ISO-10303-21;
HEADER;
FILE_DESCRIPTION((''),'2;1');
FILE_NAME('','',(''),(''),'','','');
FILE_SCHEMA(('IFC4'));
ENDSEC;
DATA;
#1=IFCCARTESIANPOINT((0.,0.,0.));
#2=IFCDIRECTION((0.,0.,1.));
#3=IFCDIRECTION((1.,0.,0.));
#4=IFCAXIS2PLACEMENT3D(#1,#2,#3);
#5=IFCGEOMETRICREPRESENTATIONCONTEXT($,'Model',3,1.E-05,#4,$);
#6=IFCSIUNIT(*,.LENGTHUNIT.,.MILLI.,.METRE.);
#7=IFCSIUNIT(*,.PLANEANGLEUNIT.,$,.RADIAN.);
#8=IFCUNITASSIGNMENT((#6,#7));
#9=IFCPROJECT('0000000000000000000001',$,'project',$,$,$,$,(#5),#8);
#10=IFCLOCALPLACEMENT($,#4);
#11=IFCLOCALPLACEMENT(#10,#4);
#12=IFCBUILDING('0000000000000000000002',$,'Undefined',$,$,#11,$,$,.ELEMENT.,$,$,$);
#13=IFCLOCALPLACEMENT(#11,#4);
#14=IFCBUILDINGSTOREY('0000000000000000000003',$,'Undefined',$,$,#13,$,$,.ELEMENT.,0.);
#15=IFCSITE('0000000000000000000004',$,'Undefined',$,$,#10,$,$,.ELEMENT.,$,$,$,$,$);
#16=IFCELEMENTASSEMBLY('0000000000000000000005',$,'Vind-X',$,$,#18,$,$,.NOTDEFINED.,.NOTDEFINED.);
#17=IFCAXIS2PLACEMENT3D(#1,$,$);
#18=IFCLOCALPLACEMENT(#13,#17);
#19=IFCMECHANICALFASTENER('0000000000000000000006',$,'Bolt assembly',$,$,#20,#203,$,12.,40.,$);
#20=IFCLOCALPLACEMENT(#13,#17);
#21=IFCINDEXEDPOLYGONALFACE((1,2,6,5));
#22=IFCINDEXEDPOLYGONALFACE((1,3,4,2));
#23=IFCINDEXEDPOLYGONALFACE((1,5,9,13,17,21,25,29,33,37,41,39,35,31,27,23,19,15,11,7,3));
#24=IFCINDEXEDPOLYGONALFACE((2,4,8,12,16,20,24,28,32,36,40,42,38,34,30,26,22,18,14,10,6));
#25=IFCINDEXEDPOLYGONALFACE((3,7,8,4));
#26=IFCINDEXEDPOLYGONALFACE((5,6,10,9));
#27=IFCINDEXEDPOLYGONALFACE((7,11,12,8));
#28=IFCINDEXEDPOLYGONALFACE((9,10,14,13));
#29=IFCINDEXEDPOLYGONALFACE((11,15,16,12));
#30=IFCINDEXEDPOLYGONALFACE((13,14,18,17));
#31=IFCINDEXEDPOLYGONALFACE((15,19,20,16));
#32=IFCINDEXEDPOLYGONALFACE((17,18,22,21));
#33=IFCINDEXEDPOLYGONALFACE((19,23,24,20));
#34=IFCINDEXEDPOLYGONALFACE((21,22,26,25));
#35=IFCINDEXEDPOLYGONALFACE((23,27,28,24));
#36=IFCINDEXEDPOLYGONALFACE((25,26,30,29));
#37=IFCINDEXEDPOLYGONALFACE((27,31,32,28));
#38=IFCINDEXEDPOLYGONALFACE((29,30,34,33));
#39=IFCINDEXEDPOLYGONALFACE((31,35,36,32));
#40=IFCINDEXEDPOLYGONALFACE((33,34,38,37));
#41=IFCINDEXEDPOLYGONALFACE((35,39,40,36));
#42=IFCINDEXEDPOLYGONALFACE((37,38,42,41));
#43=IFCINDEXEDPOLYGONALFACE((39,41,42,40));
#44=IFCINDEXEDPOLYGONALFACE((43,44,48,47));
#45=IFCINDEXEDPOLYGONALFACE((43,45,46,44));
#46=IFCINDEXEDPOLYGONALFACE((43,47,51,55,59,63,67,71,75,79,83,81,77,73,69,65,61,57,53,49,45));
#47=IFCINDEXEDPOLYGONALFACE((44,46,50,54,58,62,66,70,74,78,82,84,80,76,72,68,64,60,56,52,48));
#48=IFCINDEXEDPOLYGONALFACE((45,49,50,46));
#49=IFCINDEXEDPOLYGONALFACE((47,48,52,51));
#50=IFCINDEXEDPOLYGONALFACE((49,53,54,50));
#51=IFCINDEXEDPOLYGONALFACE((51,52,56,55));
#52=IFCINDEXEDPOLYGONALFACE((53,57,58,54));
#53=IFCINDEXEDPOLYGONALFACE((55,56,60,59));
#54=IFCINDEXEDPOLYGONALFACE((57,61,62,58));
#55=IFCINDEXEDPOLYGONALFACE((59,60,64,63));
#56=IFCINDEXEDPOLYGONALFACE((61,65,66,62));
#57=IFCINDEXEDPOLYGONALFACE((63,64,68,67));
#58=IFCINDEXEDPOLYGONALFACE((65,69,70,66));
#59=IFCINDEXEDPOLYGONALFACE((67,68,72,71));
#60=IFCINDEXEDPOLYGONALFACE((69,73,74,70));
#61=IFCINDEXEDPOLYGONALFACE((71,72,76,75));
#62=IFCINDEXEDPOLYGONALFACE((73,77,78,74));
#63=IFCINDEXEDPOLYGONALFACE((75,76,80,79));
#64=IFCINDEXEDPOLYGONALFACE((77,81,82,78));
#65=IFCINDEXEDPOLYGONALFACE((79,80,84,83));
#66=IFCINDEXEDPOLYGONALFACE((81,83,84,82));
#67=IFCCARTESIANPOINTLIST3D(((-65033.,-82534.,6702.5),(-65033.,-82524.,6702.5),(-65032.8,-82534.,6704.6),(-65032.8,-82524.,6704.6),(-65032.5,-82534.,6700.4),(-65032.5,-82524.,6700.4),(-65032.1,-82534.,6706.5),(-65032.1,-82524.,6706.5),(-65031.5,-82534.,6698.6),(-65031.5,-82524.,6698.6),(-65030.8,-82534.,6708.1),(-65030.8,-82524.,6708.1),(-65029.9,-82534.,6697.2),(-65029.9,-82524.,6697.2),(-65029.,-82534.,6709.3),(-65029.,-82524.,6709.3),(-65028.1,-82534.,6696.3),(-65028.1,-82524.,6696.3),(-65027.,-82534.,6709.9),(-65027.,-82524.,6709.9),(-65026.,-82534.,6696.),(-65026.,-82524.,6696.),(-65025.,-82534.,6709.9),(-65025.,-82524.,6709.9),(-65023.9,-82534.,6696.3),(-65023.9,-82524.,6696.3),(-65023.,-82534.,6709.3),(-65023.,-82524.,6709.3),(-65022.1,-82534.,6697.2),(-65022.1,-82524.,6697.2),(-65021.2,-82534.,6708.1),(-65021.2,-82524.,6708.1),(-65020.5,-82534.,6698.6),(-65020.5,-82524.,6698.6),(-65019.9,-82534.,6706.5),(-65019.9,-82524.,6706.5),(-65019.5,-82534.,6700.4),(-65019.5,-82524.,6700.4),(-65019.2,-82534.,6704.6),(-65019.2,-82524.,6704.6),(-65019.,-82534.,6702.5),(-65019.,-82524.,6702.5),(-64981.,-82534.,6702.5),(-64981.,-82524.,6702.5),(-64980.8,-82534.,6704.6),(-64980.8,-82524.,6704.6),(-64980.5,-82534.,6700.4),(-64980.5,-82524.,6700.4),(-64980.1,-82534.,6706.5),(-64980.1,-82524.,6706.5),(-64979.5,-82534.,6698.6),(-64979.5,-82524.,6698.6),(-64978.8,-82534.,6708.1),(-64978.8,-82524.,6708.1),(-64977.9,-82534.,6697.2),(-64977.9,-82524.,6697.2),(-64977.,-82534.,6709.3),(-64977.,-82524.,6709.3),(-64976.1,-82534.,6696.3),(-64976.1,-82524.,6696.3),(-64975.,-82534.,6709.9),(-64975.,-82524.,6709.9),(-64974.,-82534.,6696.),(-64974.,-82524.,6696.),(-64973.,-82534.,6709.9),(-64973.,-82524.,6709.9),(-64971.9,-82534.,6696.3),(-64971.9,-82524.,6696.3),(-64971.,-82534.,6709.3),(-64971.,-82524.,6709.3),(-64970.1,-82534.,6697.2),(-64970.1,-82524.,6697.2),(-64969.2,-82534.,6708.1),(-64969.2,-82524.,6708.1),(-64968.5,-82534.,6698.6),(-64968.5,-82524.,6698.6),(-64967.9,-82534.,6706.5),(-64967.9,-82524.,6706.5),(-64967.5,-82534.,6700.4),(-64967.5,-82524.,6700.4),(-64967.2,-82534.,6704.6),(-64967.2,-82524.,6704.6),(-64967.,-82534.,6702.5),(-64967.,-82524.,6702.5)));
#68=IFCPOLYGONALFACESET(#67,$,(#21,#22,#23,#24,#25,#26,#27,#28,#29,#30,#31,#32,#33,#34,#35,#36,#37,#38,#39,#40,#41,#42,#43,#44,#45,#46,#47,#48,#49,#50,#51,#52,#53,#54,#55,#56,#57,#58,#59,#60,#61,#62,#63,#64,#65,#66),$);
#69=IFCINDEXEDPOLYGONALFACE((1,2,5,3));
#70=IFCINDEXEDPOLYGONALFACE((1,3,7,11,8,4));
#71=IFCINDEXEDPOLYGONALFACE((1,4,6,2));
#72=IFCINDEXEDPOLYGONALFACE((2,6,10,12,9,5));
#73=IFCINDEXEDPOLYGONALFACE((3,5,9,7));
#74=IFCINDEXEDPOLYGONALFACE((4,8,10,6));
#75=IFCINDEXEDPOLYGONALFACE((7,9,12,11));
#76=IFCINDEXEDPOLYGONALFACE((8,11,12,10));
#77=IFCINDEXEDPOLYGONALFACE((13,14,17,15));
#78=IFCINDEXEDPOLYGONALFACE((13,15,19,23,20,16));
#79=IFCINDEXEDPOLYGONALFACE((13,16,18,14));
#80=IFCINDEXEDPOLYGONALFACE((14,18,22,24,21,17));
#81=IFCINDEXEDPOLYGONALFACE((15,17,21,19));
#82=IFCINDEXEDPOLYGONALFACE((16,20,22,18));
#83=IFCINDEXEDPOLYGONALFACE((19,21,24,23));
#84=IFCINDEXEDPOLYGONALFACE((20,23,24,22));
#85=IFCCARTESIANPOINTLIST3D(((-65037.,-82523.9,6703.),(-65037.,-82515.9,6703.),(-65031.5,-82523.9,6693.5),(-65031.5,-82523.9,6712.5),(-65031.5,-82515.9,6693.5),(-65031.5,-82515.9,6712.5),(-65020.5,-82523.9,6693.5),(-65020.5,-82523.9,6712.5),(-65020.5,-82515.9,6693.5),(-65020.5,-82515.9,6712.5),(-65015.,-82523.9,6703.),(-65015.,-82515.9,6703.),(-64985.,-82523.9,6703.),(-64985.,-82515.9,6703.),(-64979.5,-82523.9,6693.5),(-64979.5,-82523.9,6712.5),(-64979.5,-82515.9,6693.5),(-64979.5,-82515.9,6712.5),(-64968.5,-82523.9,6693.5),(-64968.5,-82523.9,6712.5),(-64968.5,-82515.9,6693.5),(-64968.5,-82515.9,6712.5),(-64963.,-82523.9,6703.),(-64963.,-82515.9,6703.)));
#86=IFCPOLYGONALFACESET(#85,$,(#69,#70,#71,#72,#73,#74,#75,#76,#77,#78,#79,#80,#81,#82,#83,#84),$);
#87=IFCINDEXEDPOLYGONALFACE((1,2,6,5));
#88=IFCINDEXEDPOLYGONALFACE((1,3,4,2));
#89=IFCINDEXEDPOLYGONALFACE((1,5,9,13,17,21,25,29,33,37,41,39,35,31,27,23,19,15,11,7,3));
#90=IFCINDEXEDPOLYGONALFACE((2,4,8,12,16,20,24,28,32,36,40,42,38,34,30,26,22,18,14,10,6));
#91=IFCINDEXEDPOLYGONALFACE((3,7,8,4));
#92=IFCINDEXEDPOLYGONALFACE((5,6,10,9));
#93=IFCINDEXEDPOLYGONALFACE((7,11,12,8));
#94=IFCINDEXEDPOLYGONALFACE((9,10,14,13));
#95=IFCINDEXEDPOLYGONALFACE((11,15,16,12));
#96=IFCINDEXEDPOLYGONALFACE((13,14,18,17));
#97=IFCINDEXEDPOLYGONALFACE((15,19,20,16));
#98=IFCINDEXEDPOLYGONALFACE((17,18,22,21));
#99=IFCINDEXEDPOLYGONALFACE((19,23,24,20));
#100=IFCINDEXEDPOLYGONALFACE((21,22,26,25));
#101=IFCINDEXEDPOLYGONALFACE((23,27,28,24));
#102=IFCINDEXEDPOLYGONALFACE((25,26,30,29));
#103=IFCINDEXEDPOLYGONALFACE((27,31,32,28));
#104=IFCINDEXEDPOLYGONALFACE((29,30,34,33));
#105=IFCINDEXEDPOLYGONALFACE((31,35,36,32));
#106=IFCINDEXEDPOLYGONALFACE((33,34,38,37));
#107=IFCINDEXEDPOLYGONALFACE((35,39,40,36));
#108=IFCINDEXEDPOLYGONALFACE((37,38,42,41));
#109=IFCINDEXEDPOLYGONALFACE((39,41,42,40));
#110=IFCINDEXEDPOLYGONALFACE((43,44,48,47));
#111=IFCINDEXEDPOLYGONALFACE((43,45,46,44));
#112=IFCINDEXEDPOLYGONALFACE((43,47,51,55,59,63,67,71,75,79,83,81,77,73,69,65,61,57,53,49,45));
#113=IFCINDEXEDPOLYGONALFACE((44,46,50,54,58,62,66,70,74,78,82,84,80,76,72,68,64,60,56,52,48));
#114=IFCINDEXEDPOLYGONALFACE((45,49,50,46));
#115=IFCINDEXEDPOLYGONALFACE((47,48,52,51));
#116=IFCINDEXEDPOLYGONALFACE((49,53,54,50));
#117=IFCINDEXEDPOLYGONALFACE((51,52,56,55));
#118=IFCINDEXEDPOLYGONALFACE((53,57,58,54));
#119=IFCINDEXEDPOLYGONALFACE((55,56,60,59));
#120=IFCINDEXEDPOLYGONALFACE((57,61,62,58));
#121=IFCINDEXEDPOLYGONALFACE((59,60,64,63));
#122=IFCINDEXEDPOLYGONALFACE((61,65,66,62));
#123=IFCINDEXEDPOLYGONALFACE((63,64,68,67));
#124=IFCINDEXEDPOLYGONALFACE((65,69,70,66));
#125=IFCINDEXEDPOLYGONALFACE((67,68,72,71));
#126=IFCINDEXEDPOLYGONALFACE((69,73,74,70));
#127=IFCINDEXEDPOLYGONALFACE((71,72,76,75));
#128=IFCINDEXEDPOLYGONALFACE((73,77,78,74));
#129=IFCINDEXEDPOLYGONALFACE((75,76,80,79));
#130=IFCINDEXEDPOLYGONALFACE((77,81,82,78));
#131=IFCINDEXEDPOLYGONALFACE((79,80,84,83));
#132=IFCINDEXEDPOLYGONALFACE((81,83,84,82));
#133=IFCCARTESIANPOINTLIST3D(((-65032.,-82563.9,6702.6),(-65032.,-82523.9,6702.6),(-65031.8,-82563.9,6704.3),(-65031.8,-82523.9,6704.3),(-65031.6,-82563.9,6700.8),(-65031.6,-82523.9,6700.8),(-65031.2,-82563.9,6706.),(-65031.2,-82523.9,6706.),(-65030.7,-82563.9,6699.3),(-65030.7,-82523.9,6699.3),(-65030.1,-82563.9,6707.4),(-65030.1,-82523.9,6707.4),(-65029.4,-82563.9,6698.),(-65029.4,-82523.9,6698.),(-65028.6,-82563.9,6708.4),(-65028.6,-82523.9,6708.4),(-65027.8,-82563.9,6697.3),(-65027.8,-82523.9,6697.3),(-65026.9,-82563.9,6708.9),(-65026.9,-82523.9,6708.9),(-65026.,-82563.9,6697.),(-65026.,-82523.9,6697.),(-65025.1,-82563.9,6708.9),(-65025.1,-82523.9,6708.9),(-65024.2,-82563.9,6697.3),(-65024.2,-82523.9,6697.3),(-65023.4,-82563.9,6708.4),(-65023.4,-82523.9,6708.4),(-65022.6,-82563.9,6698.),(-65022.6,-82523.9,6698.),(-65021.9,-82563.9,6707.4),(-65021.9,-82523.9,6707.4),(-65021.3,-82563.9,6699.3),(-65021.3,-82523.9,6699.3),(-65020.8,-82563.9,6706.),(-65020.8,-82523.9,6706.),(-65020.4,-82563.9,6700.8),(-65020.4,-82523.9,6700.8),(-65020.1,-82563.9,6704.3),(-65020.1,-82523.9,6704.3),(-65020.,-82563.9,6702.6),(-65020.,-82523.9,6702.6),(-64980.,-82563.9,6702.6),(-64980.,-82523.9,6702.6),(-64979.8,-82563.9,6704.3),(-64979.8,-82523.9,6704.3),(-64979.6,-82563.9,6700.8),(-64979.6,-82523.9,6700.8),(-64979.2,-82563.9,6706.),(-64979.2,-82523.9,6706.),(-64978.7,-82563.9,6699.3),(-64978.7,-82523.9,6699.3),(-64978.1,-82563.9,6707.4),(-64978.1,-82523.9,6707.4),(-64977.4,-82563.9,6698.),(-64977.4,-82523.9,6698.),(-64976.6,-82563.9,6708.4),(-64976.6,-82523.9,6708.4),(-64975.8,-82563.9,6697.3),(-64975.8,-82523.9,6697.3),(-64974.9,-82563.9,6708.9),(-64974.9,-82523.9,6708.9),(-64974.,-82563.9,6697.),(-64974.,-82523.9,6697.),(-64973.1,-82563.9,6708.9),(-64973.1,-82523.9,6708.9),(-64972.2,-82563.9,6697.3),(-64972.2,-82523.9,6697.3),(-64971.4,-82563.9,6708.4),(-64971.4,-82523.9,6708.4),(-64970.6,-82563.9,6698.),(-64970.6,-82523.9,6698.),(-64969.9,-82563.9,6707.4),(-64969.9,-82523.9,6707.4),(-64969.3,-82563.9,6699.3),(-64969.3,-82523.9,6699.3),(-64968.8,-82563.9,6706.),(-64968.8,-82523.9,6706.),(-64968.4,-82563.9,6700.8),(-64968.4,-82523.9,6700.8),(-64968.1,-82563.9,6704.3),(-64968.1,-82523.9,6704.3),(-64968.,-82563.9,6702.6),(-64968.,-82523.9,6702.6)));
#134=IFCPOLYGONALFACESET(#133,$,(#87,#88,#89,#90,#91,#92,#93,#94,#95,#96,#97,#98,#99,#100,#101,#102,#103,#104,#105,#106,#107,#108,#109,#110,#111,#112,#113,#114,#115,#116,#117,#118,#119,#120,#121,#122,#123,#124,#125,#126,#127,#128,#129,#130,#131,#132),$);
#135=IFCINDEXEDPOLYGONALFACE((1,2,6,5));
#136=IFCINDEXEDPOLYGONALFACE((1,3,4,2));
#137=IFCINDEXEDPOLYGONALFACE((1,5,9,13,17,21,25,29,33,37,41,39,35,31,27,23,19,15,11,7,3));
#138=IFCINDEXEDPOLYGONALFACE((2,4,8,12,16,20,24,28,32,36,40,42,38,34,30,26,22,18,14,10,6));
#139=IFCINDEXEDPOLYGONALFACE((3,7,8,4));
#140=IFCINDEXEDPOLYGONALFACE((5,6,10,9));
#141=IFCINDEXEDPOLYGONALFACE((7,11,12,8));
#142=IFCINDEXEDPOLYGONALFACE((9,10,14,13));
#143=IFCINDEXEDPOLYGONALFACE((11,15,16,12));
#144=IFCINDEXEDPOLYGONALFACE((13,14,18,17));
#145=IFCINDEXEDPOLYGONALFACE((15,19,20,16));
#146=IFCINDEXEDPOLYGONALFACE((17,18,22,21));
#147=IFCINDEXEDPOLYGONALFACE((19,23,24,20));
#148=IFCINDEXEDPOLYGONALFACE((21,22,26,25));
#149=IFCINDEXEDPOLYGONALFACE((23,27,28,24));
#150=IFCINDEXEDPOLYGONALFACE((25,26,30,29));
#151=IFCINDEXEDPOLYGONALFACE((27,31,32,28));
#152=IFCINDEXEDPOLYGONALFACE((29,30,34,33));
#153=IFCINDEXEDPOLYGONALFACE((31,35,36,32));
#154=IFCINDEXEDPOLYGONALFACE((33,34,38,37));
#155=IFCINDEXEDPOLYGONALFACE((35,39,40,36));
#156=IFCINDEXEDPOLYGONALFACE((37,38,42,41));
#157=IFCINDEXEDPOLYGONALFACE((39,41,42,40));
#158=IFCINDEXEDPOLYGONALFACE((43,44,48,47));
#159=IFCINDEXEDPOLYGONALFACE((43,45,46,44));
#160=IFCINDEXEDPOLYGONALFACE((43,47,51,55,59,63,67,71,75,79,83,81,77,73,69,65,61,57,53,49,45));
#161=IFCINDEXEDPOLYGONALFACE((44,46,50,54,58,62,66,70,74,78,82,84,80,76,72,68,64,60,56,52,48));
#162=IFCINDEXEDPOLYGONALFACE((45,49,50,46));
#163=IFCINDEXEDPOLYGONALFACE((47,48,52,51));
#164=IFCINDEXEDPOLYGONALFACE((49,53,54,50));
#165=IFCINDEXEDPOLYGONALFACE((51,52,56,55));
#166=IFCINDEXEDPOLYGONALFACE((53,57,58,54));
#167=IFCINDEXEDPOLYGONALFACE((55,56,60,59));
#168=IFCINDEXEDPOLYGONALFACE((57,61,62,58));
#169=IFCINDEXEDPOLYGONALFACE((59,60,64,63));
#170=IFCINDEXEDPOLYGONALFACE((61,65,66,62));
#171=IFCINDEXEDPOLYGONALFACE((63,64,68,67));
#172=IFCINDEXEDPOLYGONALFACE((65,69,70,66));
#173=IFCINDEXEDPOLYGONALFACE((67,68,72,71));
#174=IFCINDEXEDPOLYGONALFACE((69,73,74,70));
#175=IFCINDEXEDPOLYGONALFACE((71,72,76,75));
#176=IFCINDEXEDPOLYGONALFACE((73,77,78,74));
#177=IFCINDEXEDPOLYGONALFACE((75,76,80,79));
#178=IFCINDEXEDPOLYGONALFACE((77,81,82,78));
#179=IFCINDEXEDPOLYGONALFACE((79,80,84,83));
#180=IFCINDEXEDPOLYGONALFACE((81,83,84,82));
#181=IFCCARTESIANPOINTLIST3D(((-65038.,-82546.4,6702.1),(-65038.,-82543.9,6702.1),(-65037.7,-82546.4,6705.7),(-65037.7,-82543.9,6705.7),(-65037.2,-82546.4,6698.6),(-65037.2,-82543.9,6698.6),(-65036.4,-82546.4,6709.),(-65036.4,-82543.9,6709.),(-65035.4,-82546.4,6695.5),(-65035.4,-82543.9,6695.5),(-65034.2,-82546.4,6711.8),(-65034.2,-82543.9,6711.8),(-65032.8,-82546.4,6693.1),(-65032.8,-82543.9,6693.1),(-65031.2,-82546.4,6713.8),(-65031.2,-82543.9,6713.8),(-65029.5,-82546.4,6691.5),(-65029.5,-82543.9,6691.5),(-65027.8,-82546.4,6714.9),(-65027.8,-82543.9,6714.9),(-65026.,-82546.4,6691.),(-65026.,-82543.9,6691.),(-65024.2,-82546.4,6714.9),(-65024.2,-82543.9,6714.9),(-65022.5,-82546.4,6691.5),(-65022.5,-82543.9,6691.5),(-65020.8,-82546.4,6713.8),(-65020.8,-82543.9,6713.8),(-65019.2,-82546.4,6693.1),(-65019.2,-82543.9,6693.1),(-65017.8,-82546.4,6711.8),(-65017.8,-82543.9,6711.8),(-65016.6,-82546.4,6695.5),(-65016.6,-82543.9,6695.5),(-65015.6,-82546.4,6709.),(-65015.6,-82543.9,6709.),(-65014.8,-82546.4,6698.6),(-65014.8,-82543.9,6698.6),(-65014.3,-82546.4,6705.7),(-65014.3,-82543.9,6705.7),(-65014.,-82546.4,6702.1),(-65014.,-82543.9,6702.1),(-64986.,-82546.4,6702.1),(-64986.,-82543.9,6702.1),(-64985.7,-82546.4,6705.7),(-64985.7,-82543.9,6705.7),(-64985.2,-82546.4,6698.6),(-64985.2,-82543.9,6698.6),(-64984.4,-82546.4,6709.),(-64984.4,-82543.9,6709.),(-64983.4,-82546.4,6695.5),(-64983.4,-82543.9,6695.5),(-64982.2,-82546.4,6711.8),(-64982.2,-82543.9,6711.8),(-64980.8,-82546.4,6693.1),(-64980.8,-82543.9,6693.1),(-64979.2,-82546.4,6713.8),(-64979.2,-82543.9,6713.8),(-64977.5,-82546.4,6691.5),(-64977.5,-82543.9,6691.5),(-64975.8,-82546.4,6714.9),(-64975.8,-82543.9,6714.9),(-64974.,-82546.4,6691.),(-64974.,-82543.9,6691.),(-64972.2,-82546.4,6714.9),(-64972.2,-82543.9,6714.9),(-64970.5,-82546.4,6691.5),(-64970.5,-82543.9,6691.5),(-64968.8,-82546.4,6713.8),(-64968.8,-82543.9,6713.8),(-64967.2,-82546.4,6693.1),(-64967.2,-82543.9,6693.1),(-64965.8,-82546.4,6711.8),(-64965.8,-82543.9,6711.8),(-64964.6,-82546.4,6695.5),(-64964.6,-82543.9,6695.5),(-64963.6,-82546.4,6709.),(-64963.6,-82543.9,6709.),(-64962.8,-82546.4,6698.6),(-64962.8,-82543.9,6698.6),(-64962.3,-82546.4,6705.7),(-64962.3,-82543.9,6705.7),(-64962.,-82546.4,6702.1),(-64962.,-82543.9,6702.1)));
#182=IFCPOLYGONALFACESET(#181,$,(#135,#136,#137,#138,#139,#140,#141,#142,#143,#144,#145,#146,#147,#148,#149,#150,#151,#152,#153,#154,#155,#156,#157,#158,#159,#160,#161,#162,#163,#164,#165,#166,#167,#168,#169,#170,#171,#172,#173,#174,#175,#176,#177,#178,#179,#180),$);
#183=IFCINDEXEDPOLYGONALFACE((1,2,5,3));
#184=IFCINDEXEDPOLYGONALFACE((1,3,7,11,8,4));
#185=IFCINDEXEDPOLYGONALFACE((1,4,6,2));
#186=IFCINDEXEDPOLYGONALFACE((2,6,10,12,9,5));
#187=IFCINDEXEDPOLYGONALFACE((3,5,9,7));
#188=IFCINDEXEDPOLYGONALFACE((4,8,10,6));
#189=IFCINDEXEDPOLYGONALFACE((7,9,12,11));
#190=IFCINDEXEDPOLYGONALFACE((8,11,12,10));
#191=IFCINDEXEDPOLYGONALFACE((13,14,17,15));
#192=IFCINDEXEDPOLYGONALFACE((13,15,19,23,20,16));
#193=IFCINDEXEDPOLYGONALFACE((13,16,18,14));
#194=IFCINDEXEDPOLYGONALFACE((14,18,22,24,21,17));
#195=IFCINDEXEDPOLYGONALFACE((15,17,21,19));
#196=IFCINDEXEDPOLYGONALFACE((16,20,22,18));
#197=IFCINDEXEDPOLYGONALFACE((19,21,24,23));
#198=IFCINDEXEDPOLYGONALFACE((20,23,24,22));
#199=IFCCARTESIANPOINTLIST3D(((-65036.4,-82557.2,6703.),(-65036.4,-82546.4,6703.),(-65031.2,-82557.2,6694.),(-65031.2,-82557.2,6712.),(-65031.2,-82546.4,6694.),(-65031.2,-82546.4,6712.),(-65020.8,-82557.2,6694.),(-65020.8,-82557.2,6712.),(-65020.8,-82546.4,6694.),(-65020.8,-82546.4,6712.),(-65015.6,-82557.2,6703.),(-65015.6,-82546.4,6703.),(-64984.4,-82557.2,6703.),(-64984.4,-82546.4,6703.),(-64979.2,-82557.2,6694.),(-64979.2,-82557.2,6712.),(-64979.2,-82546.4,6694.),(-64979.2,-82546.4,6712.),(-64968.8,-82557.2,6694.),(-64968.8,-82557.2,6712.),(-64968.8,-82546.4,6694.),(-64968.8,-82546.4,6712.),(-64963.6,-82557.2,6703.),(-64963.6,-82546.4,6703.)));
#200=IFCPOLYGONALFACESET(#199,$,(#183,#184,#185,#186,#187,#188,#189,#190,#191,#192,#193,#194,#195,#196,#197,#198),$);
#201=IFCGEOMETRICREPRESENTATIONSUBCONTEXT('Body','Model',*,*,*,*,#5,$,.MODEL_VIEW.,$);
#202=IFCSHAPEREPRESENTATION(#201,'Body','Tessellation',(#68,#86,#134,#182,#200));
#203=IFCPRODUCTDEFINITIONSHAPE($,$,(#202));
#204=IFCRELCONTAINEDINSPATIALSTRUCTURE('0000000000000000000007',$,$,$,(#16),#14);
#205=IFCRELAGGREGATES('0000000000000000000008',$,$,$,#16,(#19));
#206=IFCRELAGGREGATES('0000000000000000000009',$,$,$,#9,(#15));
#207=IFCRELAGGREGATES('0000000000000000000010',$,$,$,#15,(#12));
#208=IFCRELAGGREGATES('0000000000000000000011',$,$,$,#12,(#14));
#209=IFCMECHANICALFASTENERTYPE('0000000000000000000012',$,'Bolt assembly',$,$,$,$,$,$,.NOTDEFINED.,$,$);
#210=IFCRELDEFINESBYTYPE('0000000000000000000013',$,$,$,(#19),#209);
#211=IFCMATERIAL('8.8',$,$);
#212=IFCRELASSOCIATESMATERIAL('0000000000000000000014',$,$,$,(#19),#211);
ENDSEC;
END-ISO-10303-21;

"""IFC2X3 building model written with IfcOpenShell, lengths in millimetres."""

from ifc_helpers import new_model, si_unit, frame, origin_with_axes, origin_2d_with_axis, place, context, subcontext, project, spatial, polyline, circle, outline, extrude, source, transform, mapped, material, type_object, element, aggregate, save


model = new_model("IFC2X3")

# Units and contexts
model_context = context("Model", 3, precision=1e-05, world=origin_with_axes())
body_context = subcontext(model_context, "Body", "Model", "MODEL_VIEW")
ifc_project = project(units=[si_unit("LENGTHUNIT", "METRE", prefix="MILLI"), si_unit("PLANEANGLEUNIT", "RADIAN")], contexts=[model_context])

# Site, building, storey
site_placement = place(None, origin_with_axes())
site = spatial("IfcSite", under=ifc_project, at=site_placement, Name="Undefined", CompositionType="ELEMENT")
building_placement = place(site_placement, origin_with_axes())
building = spatial("IfcBuilding", under=site, at=building_placement, Name="Undefined", CompositionType="ELEMENT")
storey_placement = place(building_placement, origin_with_axes())
storey = spatial("IfcBuildingStorey", under=building, at=storey_placement, Name="Undefined", CompositionType="ELEMENT", Elevation=0.0)

# Element assembly
assembly_1_placement = place(storey_placement, origin_with_axes())
assembly_1 = element("IfcElementAssembly", 1, at=assembly_1_placement, inside=storey, Name="Vind-X", AssemblyPlace="NOTDEFINED", PredefinedType="NOTDEFINED")

# Mechanical fastener
ifc_material_1 = material(Name="8.8")
mechanical_fastener_type = type_object("IfcMechanicalFastenerType", Name="Bolt assembly")
shared_shape_1 = source(origin_with_axes(), body_context, "Body", "SweptSolid", [
    extrude(circle(Radius=7.0, at=origin_2d_with_axis()), frame((0.0, -14.9, 0.0), z_axis=(0.0, 1.0, 0.0), x_axis=(1.0, 0.0, 0.0)), (0.0, 0.0, 1.0), 10.0),
    extrude(outline(polyline([(9.5, -5.5), (9.5, 5.5), (0.0, 11.0), (-9.5, 5.5), (-9.5, -5.5), (0.0, -11.0), (9.5, -5.5)])), frame((0.0, -23.0, 0.0), z_axis=(0.0, 1.0, 0.0), x_axis=(1.0, 0.0, 0.0)), (0.0, 0.0, 1.0), 8.0),
    extrude(circle(Radius=6.0, at=origin_2d_with_axis()), frame((0.0, -15.0, 0.0), z_axis=(0.0, 1.0, 0.0), x_axis=(1.0, 0.0, 0.0)), (0.0, 0.0, 1.0), 40.0),
    extrude(circle(Radius=12.0, at=origin_2d_with_axis()), frame((0.0, 5.0, 0.0), z_axis=(0.0, 1.0, 0.0), x_axis=(1.0, 0.0, 0.0)), (0.0, 0.0, 1.0), 2.5),
    extrude(outline(polyline([(9.0, -5.2), (9.0, 5.2), (0.0, 10.4), (-9.0, 5.2), (-9.0, -5.2), (0.0, -10.4), (9.0, -5.2)])), frame((0.0, 7.5, 0.0), z_axis=(0.0, 1.0, 0.0), x_axis=(1.0, 0.0, 0.0)), (0.0, 0.0, 1.0), 10.8),
])
mechanical_fastener_1_placement = place(assembly_1_placement, frame((-65000.0, -82538.9, 6703.0), z_axis=(-1.0, 0.0, 0.0), x_axis=(0.0, 0.0, -1.0)))
mechanical_fastener_1 = element("IfcMechanicalFastener", 2, at=mechanical_fastener_1_placement, type_object=mechanical_fastener_type, material=ifc_material_1, Name="Bolt assembly", NominalDiameter=12.0, NominalLength=40.0, context=body_context, shape_type="MappedRepresentation", body=[
    mapped(shared_shape_1, transform((0.0, 0.0, -26.0))),
    mapped(shared_shape_1, transform((0.0, 0.0, 26.0))),
])
aggregate(assembly_1, [mechanical_fastener_1])

save(model, "model.ifc")
